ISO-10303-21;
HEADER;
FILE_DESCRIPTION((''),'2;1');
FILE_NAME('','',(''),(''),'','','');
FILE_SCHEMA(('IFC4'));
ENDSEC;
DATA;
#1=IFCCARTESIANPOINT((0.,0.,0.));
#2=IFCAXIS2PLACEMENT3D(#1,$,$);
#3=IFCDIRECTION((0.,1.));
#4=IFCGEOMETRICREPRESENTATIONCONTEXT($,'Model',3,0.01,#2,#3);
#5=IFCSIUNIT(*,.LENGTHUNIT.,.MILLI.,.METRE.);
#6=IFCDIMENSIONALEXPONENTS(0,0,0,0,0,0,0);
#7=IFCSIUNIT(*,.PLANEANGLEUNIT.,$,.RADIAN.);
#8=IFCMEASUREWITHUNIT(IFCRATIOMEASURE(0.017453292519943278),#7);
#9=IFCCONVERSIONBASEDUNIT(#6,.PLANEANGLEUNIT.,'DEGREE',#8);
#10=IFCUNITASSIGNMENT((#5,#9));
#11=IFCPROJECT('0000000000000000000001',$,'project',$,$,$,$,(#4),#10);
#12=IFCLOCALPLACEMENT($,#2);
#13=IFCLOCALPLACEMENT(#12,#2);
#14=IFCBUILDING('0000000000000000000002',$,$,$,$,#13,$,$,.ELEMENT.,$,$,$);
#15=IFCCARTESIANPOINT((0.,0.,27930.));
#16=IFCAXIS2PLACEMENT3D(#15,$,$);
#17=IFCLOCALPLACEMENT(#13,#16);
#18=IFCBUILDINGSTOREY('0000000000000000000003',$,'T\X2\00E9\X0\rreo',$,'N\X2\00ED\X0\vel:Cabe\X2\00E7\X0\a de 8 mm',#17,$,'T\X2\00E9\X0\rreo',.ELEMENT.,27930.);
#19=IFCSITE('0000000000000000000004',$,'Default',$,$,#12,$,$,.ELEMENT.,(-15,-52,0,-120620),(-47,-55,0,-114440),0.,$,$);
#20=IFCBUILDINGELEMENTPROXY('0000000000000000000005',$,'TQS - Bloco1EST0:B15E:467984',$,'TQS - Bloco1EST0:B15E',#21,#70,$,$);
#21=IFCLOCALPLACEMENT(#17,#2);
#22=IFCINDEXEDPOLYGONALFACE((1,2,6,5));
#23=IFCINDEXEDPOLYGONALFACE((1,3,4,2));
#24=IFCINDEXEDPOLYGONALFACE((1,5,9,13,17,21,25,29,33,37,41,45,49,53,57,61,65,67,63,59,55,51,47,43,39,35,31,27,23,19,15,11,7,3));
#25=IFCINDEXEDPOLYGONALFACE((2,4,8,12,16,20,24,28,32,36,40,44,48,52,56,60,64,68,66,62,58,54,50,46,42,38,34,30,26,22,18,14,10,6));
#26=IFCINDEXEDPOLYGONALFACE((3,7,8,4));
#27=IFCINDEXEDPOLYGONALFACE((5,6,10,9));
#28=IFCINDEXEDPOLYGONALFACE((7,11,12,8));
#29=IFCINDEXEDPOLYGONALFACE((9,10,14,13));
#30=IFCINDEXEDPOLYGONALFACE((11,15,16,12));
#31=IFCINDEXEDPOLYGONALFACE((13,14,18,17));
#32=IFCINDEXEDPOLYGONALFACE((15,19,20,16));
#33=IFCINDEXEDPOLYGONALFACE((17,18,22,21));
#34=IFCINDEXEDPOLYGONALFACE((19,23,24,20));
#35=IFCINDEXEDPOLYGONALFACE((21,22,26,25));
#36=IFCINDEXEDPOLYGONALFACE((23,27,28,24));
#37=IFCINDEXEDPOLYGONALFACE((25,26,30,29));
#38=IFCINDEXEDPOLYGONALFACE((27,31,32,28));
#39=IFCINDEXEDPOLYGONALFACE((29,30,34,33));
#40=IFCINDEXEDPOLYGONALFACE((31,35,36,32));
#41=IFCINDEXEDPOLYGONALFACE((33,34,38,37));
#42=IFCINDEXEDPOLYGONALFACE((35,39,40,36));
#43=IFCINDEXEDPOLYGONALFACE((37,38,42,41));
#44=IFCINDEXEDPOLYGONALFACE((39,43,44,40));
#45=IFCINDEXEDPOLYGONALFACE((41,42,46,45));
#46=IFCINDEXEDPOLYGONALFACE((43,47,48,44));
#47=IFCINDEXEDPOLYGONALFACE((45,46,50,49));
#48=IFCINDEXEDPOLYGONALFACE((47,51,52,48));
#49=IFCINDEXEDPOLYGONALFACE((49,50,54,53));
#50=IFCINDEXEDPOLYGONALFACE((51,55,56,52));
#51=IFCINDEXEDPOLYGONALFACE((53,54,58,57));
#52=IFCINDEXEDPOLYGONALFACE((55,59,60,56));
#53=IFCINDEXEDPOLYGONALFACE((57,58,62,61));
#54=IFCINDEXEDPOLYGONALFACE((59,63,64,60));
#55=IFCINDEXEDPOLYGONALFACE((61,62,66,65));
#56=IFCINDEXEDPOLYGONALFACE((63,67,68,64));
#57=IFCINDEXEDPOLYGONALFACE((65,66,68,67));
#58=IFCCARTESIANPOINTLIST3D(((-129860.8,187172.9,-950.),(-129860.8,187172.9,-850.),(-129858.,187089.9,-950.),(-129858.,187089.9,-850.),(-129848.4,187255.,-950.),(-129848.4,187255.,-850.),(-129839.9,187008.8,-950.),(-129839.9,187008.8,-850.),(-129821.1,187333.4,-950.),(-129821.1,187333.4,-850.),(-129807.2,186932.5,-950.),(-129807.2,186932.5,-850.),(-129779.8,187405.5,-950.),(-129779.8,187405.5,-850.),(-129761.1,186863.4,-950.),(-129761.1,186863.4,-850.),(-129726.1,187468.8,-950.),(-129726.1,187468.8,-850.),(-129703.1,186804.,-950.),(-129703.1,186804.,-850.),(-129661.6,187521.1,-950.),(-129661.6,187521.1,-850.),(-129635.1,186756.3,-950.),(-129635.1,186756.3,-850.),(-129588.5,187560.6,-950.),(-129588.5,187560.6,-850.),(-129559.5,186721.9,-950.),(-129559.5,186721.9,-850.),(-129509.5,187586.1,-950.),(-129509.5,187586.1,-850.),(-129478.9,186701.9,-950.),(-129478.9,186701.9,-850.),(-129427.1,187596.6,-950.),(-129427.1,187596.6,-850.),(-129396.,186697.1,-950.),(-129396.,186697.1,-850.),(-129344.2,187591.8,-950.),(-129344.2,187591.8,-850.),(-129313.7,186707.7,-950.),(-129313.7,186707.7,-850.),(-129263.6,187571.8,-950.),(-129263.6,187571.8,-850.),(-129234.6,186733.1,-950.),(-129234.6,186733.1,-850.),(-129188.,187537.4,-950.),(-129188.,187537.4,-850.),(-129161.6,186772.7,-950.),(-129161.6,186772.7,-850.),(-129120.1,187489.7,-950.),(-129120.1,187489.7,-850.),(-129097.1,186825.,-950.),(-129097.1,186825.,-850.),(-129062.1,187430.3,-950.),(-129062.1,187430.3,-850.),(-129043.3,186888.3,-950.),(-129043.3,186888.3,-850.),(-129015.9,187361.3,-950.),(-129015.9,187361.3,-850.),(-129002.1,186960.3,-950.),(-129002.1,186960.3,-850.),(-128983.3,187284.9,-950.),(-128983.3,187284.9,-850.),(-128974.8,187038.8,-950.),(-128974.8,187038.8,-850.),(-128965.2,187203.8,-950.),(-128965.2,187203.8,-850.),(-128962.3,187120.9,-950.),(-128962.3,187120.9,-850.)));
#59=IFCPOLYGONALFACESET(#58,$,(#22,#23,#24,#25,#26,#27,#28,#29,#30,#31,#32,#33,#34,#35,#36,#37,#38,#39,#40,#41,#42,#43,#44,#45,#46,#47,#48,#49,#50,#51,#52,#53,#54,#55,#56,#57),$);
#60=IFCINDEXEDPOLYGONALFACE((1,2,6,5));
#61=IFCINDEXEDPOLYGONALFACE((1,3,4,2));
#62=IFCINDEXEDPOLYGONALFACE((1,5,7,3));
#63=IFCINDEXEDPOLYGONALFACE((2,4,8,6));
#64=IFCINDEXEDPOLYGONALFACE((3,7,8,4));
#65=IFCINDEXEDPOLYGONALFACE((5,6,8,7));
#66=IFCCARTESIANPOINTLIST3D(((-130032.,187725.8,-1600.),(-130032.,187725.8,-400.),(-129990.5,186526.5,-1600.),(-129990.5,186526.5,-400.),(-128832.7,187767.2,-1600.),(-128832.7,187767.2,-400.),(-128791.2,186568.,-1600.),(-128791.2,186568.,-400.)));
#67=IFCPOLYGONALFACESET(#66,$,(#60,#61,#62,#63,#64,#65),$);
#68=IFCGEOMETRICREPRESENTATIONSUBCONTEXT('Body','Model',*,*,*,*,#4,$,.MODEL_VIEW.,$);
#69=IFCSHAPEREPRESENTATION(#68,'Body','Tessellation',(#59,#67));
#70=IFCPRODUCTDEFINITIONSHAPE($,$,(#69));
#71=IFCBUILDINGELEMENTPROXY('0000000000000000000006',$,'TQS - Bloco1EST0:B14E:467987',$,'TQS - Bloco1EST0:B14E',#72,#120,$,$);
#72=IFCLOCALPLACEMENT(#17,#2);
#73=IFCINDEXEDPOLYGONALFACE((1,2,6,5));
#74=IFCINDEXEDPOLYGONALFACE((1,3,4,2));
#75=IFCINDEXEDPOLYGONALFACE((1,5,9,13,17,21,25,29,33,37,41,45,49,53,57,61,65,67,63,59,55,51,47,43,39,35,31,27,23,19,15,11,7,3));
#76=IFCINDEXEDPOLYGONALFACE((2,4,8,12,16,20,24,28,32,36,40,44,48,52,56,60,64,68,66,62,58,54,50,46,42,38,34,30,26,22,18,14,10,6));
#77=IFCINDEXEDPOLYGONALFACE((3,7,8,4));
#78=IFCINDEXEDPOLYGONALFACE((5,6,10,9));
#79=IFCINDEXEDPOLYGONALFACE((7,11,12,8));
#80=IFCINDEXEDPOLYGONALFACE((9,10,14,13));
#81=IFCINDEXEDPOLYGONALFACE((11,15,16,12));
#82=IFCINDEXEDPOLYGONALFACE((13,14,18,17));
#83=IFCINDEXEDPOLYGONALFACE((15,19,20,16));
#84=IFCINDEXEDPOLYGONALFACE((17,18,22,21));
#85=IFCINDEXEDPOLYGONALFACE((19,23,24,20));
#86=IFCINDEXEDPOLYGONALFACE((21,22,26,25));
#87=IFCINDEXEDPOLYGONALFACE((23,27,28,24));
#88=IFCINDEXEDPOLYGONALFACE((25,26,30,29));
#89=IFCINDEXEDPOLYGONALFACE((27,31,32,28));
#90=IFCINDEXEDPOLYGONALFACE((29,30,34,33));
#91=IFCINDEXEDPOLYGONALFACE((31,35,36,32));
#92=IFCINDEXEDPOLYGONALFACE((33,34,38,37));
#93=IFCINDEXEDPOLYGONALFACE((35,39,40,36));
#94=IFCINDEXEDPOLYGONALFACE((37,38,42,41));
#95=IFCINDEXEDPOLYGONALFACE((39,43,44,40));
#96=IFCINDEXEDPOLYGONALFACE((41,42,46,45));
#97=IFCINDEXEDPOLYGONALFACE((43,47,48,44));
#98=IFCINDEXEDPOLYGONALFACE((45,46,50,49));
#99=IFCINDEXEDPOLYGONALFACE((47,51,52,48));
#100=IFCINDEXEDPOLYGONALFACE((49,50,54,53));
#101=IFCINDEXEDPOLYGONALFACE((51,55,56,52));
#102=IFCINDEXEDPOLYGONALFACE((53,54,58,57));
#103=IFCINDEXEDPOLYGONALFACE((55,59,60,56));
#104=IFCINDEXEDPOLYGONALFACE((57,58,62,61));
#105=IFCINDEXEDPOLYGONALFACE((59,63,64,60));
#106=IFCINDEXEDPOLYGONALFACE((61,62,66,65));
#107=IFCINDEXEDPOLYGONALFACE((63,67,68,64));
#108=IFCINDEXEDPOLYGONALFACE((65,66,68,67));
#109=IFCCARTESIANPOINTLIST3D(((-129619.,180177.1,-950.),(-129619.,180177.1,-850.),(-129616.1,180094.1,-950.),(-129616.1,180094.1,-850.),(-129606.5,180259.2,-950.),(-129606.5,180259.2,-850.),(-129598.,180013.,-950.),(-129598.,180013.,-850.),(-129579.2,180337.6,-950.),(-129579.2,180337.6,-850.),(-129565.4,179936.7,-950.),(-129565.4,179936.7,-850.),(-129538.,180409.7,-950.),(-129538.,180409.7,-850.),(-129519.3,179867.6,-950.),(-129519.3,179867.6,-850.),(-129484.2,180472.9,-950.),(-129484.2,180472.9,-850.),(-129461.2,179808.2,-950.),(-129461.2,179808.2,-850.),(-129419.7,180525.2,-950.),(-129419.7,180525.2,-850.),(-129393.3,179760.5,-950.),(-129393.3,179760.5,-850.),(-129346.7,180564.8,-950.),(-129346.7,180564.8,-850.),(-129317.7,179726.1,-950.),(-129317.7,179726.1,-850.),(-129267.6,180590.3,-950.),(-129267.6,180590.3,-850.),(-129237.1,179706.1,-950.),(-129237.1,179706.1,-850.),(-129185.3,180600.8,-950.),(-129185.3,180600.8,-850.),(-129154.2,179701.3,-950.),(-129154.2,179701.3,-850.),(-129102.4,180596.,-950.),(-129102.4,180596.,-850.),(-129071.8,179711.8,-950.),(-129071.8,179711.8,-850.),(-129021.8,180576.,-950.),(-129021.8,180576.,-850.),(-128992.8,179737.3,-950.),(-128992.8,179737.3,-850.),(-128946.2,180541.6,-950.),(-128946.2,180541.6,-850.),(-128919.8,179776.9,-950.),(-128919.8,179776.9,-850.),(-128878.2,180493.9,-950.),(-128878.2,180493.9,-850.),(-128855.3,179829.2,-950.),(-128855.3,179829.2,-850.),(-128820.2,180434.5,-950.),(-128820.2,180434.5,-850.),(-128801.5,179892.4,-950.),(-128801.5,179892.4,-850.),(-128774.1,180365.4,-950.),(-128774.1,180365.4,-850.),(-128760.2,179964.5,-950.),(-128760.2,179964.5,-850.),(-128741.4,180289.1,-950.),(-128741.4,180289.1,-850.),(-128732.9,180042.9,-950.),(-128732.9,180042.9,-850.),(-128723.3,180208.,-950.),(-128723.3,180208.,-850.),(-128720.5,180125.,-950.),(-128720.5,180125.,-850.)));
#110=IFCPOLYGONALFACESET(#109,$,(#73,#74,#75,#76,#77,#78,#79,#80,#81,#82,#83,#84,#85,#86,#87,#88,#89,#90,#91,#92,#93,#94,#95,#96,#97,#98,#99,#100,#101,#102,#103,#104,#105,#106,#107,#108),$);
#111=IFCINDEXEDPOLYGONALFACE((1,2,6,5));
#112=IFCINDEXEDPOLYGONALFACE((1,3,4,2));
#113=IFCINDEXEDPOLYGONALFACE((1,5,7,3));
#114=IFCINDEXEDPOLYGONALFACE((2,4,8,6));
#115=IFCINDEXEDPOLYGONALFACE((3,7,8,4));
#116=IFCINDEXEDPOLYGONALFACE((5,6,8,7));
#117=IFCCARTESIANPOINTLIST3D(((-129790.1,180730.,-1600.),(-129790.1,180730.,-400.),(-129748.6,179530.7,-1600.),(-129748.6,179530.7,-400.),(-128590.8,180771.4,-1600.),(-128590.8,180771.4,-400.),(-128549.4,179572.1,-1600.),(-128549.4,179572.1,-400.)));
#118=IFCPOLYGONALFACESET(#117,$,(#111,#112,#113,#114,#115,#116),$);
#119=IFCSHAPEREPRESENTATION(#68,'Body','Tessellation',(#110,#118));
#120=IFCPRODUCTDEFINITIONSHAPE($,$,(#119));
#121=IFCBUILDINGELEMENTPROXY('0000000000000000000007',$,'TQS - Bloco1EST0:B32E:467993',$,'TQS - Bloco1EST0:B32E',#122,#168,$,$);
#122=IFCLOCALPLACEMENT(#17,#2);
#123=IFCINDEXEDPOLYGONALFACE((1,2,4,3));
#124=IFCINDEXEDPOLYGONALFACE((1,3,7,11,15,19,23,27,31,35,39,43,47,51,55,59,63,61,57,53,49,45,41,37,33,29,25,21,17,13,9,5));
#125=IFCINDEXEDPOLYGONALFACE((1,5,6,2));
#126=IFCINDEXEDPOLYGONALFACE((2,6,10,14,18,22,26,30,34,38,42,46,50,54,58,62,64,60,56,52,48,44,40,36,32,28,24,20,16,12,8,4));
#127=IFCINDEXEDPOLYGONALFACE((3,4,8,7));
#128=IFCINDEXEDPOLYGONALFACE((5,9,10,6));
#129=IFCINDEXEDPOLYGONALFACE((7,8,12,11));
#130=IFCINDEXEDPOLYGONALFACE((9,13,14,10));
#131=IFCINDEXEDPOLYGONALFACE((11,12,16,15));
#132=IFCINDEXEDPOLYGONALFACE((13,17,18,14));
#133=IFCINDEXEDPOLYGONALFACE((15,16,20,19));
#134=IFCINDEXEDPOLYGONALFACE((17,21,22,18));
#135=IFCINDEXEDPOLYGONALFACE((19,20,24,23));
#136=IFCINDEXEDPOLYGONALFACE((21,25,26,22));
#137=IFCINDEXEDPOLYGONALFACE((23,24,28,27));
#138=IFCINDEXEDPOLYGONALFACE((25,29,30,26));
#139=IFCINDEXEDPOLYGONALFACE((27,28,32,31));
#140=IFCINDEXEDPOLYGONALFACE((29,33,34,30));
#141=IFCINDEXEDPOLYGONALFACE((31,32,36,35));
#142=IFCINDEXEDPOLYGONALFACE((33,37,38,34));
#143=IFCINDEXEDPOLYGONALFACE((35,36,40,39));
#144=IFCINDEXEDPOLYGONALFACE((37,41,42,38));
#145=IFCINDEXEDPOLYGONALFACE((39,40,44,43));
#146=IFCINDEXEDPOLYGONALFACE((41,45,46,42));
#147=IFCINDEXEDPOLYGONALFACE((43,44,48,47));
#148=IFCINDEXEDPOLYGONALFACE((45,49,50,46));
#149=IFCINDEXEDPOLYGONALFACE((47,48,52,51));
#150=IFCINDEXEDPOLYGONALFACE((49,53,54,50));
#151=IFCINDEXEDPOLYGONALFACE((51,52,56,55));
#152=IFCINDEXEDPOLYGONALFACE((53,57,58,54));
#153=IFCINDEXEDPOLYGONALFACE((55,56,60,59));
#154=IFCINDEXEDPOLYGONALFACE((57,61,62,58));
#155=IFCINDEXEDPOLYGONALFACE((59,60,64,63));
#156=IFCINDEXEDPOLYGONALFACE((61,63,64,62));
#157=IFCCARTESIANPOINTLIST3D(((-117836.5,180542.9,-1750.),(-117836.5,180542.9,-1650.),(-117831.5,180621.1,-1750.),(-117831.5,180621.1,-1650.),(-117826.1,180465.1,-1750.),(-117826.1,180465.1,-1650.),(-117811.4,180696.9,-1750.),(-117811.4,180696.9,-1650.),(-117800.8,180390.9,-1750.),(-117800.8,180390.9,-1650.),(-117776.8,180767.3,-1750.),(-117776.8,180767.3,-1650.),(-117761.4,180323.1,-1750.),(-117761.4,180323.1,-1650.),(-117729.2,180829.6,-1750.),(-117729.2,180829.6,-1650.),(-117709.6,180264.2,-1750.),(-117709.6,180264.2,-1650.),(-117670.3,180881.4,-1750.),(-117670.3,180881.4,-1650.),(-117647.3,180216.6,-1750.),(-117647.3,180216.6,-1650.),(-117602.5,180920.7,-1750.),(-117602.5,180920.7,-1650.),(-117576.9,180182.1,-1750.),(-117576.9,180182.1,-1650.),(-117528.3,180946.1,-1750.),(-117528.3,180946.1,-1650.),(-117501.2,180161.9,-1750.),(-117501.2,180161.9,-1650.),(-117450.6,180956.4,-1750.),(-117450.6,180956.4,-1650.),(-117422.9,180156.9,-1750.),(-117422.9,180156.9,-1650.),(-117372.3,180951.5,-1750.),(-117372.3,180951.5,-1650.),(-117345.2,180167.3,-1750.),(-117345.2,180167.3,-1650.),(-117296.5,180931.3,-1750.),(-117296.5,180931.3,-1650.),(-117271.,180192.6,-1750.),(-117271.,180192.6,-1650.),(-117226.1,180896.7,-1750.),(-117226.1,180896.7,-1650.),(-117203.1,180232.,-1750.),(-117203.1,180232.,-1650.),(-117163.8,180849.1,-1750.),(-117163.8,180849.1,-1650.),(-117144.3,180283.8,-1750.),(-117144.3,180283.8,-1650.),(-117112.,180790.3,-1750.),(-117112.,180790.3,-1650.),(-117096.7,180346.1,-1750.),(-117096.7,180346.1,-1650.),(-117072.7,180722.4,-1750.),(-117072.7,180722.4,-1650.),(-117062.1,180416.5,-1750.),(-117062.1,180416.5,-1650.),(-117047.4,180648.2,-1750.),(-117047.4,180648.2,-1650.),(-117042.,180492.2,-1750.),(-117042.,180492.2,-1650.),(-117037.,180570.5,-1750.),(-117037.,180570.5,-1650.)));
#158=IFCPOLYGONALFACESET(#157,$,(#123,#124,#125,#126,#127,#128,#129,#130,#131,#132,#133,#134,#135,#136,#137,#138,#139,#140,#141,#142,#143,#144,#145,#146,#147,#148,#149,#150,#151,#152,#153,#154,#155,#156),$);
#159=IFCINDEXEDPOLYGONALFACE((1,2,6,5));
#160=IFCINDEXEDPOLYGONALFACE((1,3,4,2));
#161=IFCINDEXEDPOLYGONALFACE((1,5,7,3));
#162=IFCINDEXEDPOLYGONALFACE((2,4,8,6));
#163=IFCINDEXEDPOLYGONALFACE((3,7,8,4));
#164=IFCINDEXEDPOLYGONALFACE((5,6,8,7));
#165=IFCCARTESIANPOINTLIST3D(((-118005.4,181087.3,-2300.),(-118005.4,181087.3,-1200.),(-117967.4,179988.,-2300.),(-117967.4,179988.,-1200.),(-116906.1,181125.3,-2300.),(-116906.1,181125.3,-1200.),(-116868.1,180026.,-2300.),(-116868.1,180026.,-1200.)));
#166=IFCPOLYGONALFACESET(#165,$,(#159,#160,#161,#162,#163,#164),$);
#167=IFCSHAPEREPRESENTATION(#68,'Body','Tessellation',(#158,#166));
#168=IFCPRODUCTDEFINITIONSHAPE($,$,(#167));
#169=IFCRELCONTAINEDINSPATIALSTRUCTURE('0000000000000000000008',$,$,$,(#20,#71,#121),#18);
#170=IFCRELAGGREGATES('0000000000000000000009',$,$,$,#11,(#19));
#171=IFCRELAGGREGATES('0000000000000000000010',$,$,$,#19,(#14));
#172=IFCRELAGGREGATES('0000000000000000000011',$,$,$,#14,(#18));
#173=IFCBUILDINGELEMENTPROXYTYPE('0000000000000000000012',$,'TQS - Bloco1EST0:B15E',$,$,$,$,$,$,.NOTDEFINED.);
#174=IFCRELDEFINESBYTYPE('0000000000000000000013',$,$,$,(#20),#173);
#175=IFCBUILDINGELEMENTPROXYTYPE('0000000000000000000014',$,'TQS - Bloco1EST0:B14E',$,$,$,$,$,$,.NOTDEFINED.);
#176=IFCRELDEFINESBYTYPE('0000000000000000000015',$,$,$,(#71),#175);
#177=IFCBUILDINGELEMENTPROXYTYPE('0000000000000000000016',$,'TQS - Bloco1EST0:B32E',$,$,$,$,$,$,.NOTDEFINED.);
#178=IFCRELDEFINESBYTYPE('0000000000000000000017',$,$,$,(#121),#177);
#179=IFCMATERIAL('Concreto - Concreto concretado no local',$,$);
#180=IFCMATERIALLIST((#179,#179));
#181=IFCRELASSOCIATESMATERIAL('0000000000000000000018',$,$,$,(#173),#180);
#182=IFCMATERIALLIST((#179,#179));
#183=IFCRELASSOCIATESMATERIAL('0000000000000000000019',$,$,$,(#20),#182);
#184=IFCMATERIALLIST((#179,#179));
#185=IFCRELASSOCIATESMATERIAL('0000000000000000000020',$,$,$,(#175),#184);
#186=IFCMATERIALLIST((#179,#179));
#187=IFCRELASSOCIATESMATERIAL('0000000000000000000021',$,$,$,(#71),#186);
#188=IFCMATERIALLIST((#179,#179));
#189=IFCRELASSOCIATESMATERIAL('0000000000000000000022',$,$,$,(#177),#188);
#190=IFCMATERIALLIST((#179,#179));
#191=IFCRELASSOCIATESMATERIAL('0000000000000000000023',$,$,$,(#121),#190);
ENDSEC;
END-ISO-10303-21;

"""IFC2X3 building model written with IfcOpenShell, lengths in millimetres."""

from ifc_helpers import new_model, entity, si_unit, converted_unit, direction, frame, frame_2d, origin, origin_2d_with_axis, place, context, subcontext, project, spatial, rectangle, circle, extrude, source, transform, mapped, material, material_list, type_object, type_shapes, element, save


model = new_model("IFC2X3")

# Units and contexts
model_context = context("Model", 3, precision=0.01, world=origin(), true_north=direction((0.0, 1.0)))
body_context = subcontext(model_context, "Body", "Model", "MODEL_VIEW")
ifc_project = project(units=[si_unit("LENGTHUNIT", "METRE", prefix="MILLI"), converted_unit("PLANEANGLEUNIT", "DEGREE", entity("IfcRatioMeasure", 0.017453292519943278), si_unit("PLANEANGLEUNIT", "RADIAN"), dimensions=[0, 0, 0, 0, 0, 0, 0])], contexts=[model_context])

# Site, building, storey
site_placement = place(None, origin())
site = spatial("IfcSite", under=ifc_project, at=site_placement, Name="Default", CompositionType="ELEMENT", RefLatitude=(-15, -52, 0, -120620), RefLongitude=(-47, -55, 0, -114440), RefElevation=0.0)
building_placement = place(site_placement, origin())
building = spatial("IfcBuilding", under=site, at=building_placement, CompositionType="ELEMENT")
storey_placement = place(building_placement, frame((0.0, 0.0, 27930.0)))
storey = spatial("IfcBuildingStorey", under=building, at=storey_placement, Name="Térreo", ObjectType="Nível:Cabeça de 8 mm", LongName="Térreo", CompositionType="ELEMENT", Elevation=27930.0)

# Building element proxies
ifc_material_1 = material(Name="Concreto - Concreto concretado no local")
ifc_material_list_1 = material_list([ifc_material_1, ifc_material_1])
ifc_material_list_2 = material_list([ifc_material_1, ifc_material_1])
building_element_proxy_type_1 = type_object("IfcBuildingElementProxyType", Name="TQS - Bloco1EST0:B15E", PredefinedType="NOTDEFINED", material=ifc_material_list_2)
shared_shape_1 = source(origin(), body_context, "Body", "SweptSolid", [
    extrude(circle(Radius=450.0, at=frame_2d((0.0, 0.0), x_axis=(1.0, 0.0))), frame((0.0, 0.0, -550.0)), (0.0, 0.0, 1.0), 100.0),
    extrude(rectangle(XDim=1200.0, YDim=1200.0, at=origin_2d_with_axis()), frame((0.0, 0.0, -1200.0), z_axis=(0.0, 0.0, 1.0), x_axis=(-1.0, 0.0, 0.0)), (0.0, 0.0, 1.0), 1200.0),
])
type_shapes(building_element_proxy_type_1, [shared_shape_1])
proxy_1_placement = place(storey_placement, frame((-129411.6, 187146.9, -400.0), z_axis=(0.0, 0.0, 1.0), x_axis=(-0.034551, 0.999403, 0.0)))
element("IfcBuildingElementProxy", 1, at=proxy_1_placement, inside=storey, type_object=building_element_proxy_type_1, material=ifc_material_list_1, Name="TQS - Bloco1EST0:B15E:467984", ObjectType="TQS - Bloco1EST0:B15E", context=body_context, shape_type="MappedRepresentation", body=[
    mapped(shared_shape_1, transform((0.0, 0.0, 0.0), scale=1.0)),
])
ifc_material_list_3 = material_list([ifc_material_1, ifc_material_1])
ifc_material_list_4 = material_list([ifc_material_1, ifc_material_1])
building_element_proxy_type_2 = type_object("IfcBuildingElementProxyType", Name="TQS - Bloco1EST0:B14E", PredefinedType="NOTDEFINED", material=ifc_material_list_4)
shared_shape_2 = source(origin(), body_context, "Body", "SweptSolid", [
    extrude(circle(Radius=450.0, at=frame_2d((0.0, 0.0), x_axis=(1.0, 0.0))), frame((0.0, 0.0, -550.0)), (0.0, 0.0, 1.0), 100.0),
    extrude(rectangle(XDim=1200.0, YDim=1200.0, at=origin_2d_with_axis()), frame((0.0, 0.0, -1200.0), z_axis=(0.0, 0.0, 1.0), x_axis=(-1.0, 0.0, 0.0)), (0.0, 0.0, 1.0), 1200.0),
])
type_shapes(building_element_proxy_type_2, [shared_shape_2])
proxy_2_placement = place(storey_placement, frame((-129169.7, 180151.1, -400.0), z_axis=(0.0, 0.0, 1.0), x_axis=(-0.034551, 0.999403, 0.0)))
element("IfcBuildingElementProxy", 2, at=proxy_2_placement, inside=storey, type_object=building_element_proxy_type_2, material=ifc_material_list_3, Name="TQS - Bloco1EST0:B14E:467987", ObjectType="TQS - Bloco1EST0:B14E", context=body_context, shape_type="MappedRepresentation", body=[
    mapped(shared_shape_2, transform((0.0, 0.0, 0.0), scale=1.0)),
])
ifc_material_list_5 = material_list([ifc_material_1, ifc_material_1])
ifc_material_list_6 = material_list([ifc_material_1, ifc_material_1])
building_element_proxy_type_3 = type_object("IfcBuildingElementProxyType", Name="TQS - Bloco1EST0:B32E", PredefinedType="NOTDEFINED", material=ifc_material_list_6)
shared_shape_3 = source(origin(), body_context, "Body", "SweptSolid", [
    extrude(circle(Radius=400.0, at=frame_2d((0.0, 0.0), x_axis=(1.0, 0.0))), frame((0.0, 0.0, -550.0)), (0.0, 0.0, 1.0), 100.0),
    extrude(rectangle(XDim=1100.0, YDim=1100.0, at=origin_2d_with_axis()), frame((0.0, 0.0, -1100.0), z_axis=(0.0, 0.0, 1.0), x_axis=(-1.0, 0.0, 0.0)), (0.0, 0.0, 1.0), 1100.0),
])
type_shapes(building_element_proxy_type_3, [shared_shape_3])
proxy_3_placement = place(storey_placement, frame((-117436.7, 180556.7, -1200.0), z_axis=(0.0, 0.0, 1.0), x_axis=(-0.034551, 0.999403, 0.0)))
element("IfcBuildingElementProxy", 3, at=proxy_3_placement, inside=storey, type_object=building_element_proxy_type_3, material=ifc_material_list_5, Name="TQS - Bloco1EST0:B32E:467993", ObjectType="TQS - Bloco1EST0:B32E", context=body_context, shape_type="MappedRepresentation", body=[
    mapped(shared_shape_3, transform((0.0, 0.0, 0.0), scale=1.0)),
])

save(model, "model.ifc")
